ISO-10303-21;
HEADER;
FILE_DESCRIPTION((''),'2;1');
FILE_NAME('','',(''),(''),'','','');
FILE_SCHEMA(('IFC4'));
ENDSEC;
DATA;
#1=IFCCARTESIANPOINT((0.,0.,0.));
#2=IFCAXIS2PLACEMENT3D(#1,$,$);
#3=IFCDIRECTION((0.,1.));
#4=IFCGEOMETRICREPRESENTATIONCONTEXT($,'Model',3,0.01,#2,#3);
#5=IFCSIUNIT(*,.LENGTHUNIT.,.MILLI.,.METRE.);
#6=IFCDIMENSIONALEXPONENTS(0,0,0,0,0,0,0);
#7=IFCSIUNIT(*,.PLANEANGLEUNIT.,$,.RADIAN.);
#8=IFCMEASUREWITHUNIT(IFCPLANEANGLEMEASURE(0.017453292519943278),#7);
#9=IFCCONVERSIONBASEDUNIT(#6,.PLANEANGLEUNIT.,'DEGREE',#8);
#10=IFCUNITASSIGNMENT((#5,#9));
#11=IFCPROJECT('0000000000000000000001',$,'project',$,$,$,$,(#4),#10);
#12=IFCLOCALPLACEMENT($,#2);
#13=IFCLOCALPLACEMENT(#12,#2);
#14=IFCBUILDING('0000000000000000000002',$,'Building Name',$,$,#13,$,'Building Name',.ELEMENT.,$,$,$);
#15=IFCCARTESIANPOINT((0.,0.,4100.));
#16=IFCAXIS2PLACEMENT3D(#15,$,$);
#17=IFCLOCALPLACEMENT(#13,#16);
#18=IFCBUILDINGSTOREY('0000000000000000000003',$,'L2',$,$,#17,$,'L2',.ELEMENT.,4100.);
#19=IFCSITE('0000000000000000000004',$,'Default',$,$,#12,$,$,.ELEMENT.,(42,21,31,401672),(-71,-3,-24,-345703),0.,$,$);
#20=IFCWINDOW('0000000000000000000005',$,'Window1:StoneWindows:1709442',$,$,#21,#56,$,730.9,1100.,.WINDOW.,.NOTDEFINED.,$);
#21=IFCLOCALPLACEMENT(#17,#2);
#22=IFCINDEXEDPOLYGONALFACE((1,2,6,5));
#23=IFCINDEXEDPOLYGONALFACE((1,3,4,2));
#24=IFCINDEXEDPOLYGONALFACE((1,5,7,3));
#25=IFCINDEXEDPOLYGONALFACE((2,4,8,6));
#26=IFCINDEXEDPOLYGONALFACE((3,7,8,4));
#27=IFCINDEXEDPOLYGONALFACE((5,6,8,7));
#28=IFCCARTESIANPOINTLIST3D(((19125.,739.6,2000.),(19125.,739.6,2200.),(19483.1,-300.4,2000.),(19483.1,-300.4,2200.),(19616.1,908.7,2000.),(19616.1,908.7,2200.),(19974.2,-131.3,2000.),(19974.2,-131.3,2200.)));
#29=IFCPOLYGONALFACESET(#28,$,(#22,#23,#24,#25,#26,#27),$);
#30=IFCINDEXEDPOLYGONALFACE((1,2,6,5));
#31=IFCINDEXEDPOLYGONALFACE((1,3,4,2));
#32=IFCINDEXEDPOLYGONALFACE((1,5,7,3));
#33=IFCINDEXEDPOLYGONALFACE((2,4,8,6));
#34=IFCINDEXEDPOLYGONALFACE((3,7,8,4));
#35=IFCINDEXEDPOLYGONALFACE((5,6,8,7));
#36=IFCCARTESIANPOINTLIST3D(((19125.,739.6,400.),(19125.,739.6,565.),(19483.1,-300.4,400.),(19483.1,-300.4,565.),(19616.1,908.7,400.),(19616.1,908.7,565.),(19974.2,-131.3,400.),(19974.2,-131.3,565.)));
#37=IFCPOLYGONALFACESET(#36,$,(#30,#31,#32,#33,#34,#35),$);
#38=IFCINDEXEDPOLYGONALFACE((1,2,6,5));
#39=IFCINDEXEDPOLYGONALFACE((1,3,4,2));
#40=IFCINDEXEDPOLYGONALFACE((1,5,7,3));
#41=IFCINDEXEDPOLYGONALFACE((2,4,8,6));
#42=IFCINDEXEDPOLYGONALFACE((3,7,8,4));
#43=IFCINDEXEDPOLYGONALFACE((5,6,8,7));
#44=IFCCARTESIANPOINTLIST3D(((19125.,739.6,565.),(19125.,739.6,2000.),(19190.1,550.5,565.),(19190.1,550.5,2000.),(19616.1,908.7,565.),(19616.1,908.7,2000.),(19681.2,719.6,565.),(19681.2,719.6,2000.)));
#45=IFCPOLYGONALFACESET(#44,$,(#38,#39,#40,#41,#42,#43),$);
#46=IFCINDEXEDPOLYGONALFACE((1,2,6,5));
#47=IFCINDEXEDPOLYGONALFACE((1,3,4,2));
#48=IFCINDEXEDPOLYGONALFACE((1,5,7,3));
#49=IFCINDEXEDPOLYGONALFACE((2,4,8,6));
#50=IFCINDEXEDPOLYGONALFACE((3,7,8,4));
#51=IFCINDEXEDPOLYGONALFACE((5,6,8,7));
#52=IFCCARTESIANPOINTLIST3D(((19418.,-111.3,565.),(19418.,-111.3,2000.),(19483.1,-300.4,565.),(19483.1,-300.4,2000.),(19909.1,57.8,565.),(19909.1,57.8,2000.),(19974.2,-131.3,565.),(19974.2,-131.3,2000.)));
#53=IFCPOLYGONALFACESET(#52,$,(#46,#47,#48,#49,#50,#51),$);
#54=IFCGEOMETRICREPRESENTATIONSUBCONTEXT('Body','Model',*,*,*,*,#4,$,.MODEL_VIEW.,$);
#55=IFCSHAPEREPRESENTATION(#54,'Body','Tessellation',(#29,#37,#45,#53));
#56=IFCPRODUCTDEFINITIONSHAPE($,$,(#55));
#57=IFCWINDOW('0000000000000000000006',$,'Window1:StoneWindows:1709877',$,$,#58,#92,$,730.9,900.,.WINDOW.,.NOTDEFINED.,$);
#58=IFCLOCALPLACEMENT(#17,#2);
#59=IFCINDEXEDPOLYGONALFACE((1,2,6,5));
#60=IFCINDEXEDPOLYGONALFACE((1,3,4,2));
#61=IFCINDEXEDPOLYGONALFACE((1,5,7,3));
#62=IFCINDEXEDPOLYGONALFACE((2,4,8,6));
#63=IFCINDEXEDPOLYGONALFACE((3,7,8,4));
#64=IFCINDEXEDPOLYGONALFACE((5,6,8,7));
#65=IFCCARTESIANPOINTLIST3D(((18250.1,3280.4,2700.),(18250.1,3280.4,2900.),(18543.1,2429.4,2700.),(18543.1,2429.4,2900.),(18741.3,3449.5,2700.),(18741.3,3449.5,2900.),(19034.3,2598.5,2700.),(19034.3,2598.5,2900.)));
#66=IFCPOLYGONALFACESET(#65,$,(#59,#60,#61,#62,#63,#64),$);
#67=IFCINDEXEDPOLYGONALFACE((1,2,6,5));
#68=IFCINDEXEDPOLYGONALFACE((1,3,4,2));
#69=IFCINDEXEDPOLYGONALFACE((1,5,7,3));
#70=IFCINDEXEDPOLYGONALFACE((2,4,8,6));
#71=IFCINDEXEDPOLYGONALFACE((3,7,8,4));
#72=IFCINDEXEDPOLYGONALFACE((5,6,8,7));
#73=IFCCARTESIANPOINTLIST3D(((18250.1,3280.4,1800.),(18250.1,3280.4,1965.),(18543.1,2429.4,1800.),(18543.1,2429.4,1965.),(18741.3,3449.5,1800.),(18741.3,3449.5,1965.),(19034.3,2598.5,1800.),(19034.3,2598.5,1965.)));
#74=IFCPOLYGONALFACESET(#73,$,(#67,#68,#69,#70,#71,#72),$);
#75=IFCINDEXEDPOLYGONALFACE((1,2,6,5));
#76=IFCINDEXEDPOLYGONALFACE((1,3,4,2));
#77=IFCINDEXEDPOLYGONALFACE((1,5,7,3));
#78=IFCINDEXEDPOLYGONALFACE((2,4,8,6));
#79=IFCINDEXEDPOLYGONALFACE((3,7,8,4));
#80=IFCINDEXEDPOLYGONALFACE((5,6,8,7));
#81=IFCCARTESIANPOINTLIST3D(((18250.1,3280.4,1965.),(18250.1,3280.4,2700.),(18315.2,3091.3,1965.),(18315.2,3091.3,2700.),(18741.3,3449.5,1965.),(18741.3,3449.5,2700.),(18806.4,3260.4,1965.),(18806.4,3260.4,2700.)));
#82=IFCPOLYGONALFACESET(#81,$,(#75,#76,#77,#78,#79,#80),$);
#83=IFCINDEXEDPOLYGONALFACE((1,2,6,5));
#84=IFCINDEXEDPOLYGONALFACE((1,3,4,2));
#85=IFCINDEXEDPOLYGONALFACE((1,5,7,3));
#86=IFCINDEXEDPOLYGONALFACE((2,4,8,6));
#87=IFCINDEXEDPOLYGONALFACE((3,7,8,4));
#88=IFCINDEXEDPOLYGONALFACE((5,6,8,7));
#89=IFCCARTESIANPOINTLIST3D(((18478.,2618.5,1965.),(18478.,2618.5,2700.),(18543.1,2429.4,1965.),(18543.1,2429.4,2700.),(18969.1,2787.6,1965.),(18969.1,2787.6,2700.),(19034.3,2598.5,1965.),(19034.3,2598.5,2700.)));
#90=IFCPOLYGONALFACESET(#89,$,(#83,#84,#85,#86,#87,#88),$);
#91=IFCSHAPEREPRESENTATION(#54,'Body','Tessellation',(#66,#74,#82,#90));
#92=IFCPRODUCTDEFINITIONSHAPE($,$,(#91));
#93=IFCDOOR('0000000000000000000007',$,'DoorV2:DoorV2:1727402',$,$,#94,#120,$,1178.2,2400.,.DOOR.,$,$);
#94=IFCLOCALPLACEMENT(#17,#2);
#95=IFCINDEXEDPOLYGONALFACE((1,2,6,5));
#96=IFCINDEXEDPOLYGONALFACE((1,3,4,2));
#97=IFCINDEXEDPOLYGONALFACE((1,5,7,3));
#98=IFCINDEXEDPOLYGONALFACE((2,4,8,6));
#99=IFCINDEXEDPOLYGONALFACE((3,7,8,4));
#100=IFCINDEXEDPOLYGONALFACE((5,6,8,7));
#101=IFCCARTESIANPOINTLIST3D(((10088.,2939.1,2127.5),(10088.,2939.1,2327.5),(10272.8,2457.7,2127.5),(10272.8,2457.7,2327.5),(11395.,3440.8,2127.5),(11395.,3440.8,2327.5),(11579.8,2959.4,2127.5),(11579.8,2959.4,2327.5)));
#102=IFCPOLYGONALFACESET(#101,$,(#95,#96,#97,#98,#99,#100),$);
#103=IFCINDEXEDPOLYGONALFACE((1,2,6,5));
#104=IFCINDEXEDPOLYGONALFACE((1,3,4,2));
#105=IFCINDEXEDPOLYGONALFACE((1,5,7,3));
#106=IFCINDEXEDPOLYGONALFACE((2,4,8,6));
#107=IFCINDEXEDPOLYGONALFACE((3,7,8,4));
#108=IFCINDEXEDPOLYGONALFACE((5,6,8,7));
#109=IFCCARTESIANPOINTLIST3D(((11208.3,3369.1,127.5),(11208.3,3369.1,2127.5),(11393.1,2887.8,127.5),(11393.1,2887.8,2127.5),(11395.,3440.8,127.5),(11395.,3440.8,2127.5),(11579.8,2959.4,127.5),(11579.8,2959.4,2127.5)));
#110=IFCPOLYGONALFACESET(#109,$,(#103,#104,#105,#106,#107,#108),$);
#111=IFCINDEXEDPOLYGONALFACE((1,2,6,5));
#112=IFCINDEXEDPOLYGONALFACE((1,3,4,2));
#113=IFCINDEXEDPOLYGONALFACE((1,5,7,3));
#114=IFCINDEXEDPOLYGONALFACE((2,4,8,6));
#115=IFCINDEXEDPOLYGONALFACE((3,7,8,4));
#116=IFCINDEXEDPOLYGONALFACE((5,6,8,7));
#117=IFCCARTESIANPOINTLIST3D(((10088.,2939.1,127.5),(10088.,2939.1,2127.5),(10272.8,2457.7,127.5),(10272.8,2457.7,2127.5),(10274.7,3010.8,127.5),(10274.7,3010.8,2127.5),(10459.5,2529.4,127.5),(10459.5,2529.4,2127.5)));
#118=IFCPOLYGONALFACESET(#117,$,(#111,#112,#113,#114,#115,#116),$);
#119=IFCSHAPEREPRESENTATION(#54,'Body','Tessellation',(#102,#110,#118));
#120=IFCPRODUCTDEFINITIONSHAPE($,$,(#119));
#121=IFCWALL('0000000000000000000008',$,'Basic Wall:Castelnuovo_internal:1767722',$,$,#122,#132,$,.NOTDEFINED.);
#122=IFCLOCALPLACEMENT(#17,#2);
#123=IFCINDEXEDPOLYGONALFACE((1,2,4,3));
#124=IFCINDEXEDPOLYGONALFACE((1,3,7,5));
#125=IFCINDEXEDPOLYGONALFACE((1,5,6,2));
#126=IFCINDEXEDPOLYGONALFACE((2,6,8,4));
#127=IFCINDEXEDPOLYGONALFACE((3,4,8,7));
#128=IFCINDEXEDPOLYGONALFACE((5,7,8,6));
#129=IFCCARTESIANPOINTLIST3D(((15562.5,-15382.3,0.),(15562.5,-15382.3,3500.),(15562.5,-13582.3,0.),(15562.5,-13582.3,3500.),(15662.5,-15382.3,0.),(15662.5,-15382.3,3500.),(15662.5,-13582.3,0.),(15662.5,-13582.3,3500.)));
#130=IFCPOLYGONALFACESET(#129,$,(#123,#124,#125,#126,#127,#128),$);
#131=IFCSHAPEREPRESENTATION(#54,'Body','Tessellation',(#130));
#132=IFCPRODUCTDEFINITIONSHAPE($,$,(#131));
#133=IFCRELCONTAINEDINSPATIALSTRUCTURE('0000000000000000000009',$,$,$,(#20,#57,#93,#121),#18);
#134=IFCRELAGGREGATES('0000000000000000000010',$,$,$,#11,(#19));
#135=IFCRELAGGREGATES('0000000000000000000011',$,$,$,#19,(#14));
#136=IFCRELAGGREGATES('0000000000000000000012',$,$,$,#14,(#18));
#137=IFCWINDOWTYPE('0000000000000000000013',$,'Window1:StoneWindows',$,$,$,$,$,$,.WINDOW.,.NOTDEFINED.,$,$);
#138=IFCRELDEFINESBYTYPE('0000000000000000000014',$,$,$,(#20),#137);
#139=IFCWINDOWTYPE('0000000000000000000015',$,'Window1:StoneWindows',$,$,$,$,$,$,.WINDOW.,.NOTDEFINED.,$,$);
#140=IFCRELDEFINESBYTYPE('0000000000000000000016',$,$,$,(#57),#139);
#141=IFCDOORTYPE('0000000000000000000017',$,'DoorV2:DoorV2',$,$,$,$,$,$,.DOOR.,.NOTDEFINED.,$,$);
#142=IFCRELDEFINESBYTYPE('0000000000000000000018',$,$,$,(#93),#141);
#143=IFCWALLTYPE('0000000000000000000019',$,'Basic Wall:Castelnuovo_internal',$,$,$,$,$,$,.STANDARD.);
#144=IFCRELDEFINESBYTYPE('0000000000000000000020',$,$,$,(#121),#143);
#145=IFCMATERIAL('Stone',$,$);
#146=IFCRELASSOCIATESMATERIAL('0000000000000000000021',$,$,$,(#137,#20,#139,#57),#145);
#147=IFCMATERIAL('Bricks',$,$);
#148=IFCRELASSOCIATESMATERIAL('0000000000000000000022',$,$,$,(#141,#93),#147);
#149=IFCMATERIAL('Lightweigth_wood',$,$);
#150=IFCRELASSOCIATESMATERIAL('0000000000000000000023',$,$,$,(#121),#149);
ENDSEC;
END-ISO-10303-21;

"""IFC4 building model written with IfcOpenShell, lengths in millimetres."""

from ifc_helpers import new_model, entity, si_unit, converted_unit, direction, frame, origin, place, context, subcontext, project, spatial, indexed_curve, outline, extrude, source, transform, mapped, material, type_object, type_shapes, element, save


model = new_model("IFC4")

# Units and contexts
model_context = context("Model", 3, precision=0.01, world=origin(), true_north=direction((0.0, 1.0)))
body_context = subcontext(model_context, "Body", "Model", "MODEL_VIEW")
ifc_project = project(units=[si_unit("LENGTHUNIT", "METRE", prefix="MILLI"), converted_unit("PLANEANGLEUNIT", "DEGREE", entity("IfcPlaneAngleMeasure", 0.017453292519943278), si_unit("PLANEANGLEUNIT", "RADIAN"), dimensions=[0, 0, 0, 0, 0, 0, 0])], contexts=[model_context])

# Site, building, storey
site_placement = place(None, origin())
site = spatial("IfcSite", under=ifc_project, at=site_placement, Name="Default", CompositionType="ELEMENT", RefLatitude=(42, 21, 31, 401672), RefLongitude=(-71, -3, -24, -345703), RefElevation=0.0)
building_placement = place(site_placement, origin())
building = spatial("IfcBuilding", under=site, at=building_placement, Name="Building Name", LongName="Building Name", CompositionType="ELEMENT")
storey_placement = place(building_placement, frame((0.0, 0.0, 4100.0)))
storey = spatial("IfcBuildingStorey", under=building, at=storey_placement, Name="L2", LongName="L2", CompositionType="ELEMENT", Elevation=4100.0)

# Shared definitions
ifc_material_1 = material(Name="Stone")

# Windows
window_type_1 = type_object("IfcWindowType", Name="Window1:StoneWindows", PartitioningType="NOTDEFINED", PredefinedType="WINDOW", material=ifc_material_1)
shared_shape_1 = source(origin(), body_context, "Body", "SweptSolid", [
    extrude(outline(indexed_curve([(-259.7, -550.0), (259.7, -550.0), (259.7, 550.0), (-259.7, 550.0), (-259.7, -550.0)], self_intersect=False)), frame((0.0, 0.0, 2400.0), z_axis=(0.0, 0.0, 1.0), x_axis=(0.0, 1.0, 0.0)), (0.0, 0.0, 1.0), 200.0),
    extrude(outline(indexed_curve([(-259.7, -550.0), (259.7, -550.0), (259.7, 550.0), (-259.7, 550.0), (-259.7, -550.0)], self_intersect=False)), frame((0.0, 0.0, 800.0), z_axis=(0.0, 0.0, 1.0), x_axis=(0.0, 1.0, 0.0)), (0.0, 0.0, 1.0), 165.0),
    extrude(outline(indexed_curve([(-259.7, -100.0), (259.7, -100.0), (259.7, 100.0), (-259.7, 100.0), (-259.7, -100.0)], self_intersect=False)), frame((-450.0, 0.0, 965.0), z_axis=(0.0, 0.0, 1.0), x_axis=(0.0, 1.0, 0.0)), (0.0, 0.0, 1.0), 1435.0),
    extrude(outline(indexed_curve([(-259.7, -100.0), (259.7, -100.0), (259.7, 100.0), (-259.7, 100.0), (-259.7, -100.0)], self_intersect=False)), frame((450.0, 0.0, 965.0), z_axis=(0.0, 0.0, 1.0), x_axis=(0.0, 1.0, 0.0)), (0.0, 0.0, 1.0), 1435.0),
])
type_shapes(window_type_1, [shared_shape_1])
for number, where, z_axis, x_axis, name in (
    (1, (19549.6, 304.2, -400.0), (0.0, 0.0, 1.0), (0.325568, -0.945519, 0.0), "Window1:StoneWindows:1709442"),
):
    element("IfcWindow", number, at=place(storey_placement, frame(where, z_axis=z_axis, x_axis=x_axis)), inside=storey, type_object=window_type_1, material=ifc_material_1, Name=name, OverallHeight=730.9, OverallWidth=1100.0, PartitioningType="NOTDEFINED", PredefinedType="WINDOW", context=body_context, shape_type="MappedRepresentation", body=[
        mapped(shared_shape_1, transform((0.0, 0.0, 0.0), scale=1.0)),
    ])
window_type_2 = type_object("IfcWindowType", Name="Window1:StoneWindows", PartitioningType="NOTDEFINED", PredefinedType="WINDOW", material=ifc_material_1)
shared_shape_2 = source(origin(), body_context, "Body", "SweptSolid", [
    extrude(outline(indexed_curve([(-259.7, -450.0), (259.7, -450.0), (259.7, 450.0), (-259.7, 450.0), (-259.7, -450.0)], self_intersect=False)), frame((0.0, 0.0, 1700.0), z_axis=(0.0, 0.0, 1.0), x_axis=(0.0, 1.0, 0.0)), (0.0, 0.0, 1.0), 200.0),
    extrude(outline(indexed_curve([(-259.7, -450.0), (259.7, -450.0), (259.7, 450.0), (-259.7, 450.0), (-259.7, -450.0)], self_intersect=False)), frame((0.0, 0.0, 800.0), z_axis=(0.0, 0.0, 1.0), x_axis=(0.0, 1.0, 0.0)), (0.0, 0.0, 1.0), 165.0),
    extrude(outline(indexed_curve([(-259.7, -100.0), (259.7, -100.0), (259.7, 100.0), (-259.7, 100.0), (-259.7, -100.0)], self_intersect=False)), frame((-350.0, 0.0, 965.0), z_axis=(0.0, 0.0, 1.0), x_axis=(0.0, 1.0, 0.0)), (0.0, 0.0, 1.0), 735.0),
    extrude(outline(indexed_curve([(-259.7, -100.0), (259.7, -100.0), (259.7, 100.0), (-259.7, 100.0), (-259.7, -100.0)], self_intersect=False)), frame((350.0, 0.0, 965.0), z_axis=(0.0, 0.0, 1.0), x_axis=(0.0, 1.0, 0.0)), (0.0, 0.0, 1.0), 735.0),
])
type_shapes(window_type_2, [shared_shape_2])
window_1_placement = place(storey_placement, frame((18642.2, 2939.5, 1000.0), z_axis=(0.0, 0.0, 1.0), x_axis=(0.325568, -0.945519, 0.0)))
element("IfcWindow", 2, at=window_1_placement, inside=storey, type_object=window_type_2, material=ifc_material_1, Name="Window1:StoneWindows:1709877", OverallHeight=730.9, OverallWidth=900.0, PartitioningType="NOTDEFINED", PredefinedType="WINDOW", context=body_context, shape_type="MappedRepresentation", body=[
    mapped(shared_shape_2, transform((0.0, 0.0, 0.0), scale=1.0)),
])

# Door
ifc_material_2 = material(Name="Bricks")
door_type = type_object("IfcDoorType", Name="DoorV2:DoorV2", OperationType="NOTDEFINED", PredefinedType="DOOR", material=ifc_material_2)
shared_shape_3 = source(origin(), body_context, "Body", "SweptSolid", [
    extrude(outline(indexed_curve([(-257.8, -700.0), (257.8, -700.0), (257.8, 700.0), (-257.8, 700.0), (-257.8, -700.0)], self_intersect=False)), frame((0.0, 0.0, 2000.0), z_axis=(0.0, 0.0, 1.0), x_axis=(0.0, 1.0, 0.0)), (0.0, 0.0, 1.0), 200.0),
    extrude(outline(indexed_curve([(-257.8, -100.0), (257.8, -100.0), (257.8, 100.0), (-257.8, 100.0), (-257.8, -100.0)], self_intersect=False)), frame((600.0, 0.0, 0.0), z_axis=(0.0, 0.0, 1.0), x_axis=(0.0, 1.0, 0.0)), (0.0, 0.0, 1.0), 2000.0),
    extrude(outline(indexed_curve([(-257.8, -100.0), (257.8, -100.0), (257.8, 100.0), (-257.8, 100.0), (-257.8, -100.0)], self_intersect=False)), frame((-600.0, 0.0, 0.0), z_axis=(0.0, 0.0, 1.0), x_axis=(0.0, 1.0, 0.0)), (0.0, 0.0, 1.0), 2000.0),
])
type_shapes(door_type, [shared_shape_3])
door_placement = place(storey_placement, frame((10833.9, 2949.3, 127.5), z_axis=(0.0, 0.0, 1.0), x_axis=(0.93358, 0.358368, 0.0)))
element("IfcDoor", 3, at=door_placement, inside=storey, type_object=door_type, material=ifc_material_2, Name="DoorV2:DoorV2:1727402", OverallHeight=1178.2, OverallWidth=2400.0, PredefinedType="DOOR", context=body_context, shape_type="MappedRepresentation", body=[
    mapped(shared_shape_3, transform((0.0, 0.0, 0.0), scale=1.0)),
])

# Wall
ifc_material_3 = material(Name="Lightweigth_wood")
wall_type_1 = type_object("IfcWallType", Name="Basic Wall:Castelnuovo_internal", PredefinedType="STANDARD")
wall_1_placement = place(storey_placement, frame((15612.5, -15382.3, 0.0), z_axis=(0.0, 0.0, 1.0), x_axis=(0.0, 1.0, 0.0)))
element("IfcWall", 4, at=wall_1_placement, inside=storey, type_object=wall_type_1, material=ifc_material_3, Name="Basic Wall:Castelnuovo_internal:1767722", PredefinedType="NOTDEFINED", context=body_context, shape_type="SweptSolid", body=[
    extrude(outline(indexed_curve([(1800.0, 50.0), (0.0, 50.0), (0.0, -50.0), (1800.0, -50.0), (1800.0, 50.0)], self_intersect=False)), origin(), (0.0, 0.0, 1.0), 3500.0),
])

save(model, "model.ifc")
